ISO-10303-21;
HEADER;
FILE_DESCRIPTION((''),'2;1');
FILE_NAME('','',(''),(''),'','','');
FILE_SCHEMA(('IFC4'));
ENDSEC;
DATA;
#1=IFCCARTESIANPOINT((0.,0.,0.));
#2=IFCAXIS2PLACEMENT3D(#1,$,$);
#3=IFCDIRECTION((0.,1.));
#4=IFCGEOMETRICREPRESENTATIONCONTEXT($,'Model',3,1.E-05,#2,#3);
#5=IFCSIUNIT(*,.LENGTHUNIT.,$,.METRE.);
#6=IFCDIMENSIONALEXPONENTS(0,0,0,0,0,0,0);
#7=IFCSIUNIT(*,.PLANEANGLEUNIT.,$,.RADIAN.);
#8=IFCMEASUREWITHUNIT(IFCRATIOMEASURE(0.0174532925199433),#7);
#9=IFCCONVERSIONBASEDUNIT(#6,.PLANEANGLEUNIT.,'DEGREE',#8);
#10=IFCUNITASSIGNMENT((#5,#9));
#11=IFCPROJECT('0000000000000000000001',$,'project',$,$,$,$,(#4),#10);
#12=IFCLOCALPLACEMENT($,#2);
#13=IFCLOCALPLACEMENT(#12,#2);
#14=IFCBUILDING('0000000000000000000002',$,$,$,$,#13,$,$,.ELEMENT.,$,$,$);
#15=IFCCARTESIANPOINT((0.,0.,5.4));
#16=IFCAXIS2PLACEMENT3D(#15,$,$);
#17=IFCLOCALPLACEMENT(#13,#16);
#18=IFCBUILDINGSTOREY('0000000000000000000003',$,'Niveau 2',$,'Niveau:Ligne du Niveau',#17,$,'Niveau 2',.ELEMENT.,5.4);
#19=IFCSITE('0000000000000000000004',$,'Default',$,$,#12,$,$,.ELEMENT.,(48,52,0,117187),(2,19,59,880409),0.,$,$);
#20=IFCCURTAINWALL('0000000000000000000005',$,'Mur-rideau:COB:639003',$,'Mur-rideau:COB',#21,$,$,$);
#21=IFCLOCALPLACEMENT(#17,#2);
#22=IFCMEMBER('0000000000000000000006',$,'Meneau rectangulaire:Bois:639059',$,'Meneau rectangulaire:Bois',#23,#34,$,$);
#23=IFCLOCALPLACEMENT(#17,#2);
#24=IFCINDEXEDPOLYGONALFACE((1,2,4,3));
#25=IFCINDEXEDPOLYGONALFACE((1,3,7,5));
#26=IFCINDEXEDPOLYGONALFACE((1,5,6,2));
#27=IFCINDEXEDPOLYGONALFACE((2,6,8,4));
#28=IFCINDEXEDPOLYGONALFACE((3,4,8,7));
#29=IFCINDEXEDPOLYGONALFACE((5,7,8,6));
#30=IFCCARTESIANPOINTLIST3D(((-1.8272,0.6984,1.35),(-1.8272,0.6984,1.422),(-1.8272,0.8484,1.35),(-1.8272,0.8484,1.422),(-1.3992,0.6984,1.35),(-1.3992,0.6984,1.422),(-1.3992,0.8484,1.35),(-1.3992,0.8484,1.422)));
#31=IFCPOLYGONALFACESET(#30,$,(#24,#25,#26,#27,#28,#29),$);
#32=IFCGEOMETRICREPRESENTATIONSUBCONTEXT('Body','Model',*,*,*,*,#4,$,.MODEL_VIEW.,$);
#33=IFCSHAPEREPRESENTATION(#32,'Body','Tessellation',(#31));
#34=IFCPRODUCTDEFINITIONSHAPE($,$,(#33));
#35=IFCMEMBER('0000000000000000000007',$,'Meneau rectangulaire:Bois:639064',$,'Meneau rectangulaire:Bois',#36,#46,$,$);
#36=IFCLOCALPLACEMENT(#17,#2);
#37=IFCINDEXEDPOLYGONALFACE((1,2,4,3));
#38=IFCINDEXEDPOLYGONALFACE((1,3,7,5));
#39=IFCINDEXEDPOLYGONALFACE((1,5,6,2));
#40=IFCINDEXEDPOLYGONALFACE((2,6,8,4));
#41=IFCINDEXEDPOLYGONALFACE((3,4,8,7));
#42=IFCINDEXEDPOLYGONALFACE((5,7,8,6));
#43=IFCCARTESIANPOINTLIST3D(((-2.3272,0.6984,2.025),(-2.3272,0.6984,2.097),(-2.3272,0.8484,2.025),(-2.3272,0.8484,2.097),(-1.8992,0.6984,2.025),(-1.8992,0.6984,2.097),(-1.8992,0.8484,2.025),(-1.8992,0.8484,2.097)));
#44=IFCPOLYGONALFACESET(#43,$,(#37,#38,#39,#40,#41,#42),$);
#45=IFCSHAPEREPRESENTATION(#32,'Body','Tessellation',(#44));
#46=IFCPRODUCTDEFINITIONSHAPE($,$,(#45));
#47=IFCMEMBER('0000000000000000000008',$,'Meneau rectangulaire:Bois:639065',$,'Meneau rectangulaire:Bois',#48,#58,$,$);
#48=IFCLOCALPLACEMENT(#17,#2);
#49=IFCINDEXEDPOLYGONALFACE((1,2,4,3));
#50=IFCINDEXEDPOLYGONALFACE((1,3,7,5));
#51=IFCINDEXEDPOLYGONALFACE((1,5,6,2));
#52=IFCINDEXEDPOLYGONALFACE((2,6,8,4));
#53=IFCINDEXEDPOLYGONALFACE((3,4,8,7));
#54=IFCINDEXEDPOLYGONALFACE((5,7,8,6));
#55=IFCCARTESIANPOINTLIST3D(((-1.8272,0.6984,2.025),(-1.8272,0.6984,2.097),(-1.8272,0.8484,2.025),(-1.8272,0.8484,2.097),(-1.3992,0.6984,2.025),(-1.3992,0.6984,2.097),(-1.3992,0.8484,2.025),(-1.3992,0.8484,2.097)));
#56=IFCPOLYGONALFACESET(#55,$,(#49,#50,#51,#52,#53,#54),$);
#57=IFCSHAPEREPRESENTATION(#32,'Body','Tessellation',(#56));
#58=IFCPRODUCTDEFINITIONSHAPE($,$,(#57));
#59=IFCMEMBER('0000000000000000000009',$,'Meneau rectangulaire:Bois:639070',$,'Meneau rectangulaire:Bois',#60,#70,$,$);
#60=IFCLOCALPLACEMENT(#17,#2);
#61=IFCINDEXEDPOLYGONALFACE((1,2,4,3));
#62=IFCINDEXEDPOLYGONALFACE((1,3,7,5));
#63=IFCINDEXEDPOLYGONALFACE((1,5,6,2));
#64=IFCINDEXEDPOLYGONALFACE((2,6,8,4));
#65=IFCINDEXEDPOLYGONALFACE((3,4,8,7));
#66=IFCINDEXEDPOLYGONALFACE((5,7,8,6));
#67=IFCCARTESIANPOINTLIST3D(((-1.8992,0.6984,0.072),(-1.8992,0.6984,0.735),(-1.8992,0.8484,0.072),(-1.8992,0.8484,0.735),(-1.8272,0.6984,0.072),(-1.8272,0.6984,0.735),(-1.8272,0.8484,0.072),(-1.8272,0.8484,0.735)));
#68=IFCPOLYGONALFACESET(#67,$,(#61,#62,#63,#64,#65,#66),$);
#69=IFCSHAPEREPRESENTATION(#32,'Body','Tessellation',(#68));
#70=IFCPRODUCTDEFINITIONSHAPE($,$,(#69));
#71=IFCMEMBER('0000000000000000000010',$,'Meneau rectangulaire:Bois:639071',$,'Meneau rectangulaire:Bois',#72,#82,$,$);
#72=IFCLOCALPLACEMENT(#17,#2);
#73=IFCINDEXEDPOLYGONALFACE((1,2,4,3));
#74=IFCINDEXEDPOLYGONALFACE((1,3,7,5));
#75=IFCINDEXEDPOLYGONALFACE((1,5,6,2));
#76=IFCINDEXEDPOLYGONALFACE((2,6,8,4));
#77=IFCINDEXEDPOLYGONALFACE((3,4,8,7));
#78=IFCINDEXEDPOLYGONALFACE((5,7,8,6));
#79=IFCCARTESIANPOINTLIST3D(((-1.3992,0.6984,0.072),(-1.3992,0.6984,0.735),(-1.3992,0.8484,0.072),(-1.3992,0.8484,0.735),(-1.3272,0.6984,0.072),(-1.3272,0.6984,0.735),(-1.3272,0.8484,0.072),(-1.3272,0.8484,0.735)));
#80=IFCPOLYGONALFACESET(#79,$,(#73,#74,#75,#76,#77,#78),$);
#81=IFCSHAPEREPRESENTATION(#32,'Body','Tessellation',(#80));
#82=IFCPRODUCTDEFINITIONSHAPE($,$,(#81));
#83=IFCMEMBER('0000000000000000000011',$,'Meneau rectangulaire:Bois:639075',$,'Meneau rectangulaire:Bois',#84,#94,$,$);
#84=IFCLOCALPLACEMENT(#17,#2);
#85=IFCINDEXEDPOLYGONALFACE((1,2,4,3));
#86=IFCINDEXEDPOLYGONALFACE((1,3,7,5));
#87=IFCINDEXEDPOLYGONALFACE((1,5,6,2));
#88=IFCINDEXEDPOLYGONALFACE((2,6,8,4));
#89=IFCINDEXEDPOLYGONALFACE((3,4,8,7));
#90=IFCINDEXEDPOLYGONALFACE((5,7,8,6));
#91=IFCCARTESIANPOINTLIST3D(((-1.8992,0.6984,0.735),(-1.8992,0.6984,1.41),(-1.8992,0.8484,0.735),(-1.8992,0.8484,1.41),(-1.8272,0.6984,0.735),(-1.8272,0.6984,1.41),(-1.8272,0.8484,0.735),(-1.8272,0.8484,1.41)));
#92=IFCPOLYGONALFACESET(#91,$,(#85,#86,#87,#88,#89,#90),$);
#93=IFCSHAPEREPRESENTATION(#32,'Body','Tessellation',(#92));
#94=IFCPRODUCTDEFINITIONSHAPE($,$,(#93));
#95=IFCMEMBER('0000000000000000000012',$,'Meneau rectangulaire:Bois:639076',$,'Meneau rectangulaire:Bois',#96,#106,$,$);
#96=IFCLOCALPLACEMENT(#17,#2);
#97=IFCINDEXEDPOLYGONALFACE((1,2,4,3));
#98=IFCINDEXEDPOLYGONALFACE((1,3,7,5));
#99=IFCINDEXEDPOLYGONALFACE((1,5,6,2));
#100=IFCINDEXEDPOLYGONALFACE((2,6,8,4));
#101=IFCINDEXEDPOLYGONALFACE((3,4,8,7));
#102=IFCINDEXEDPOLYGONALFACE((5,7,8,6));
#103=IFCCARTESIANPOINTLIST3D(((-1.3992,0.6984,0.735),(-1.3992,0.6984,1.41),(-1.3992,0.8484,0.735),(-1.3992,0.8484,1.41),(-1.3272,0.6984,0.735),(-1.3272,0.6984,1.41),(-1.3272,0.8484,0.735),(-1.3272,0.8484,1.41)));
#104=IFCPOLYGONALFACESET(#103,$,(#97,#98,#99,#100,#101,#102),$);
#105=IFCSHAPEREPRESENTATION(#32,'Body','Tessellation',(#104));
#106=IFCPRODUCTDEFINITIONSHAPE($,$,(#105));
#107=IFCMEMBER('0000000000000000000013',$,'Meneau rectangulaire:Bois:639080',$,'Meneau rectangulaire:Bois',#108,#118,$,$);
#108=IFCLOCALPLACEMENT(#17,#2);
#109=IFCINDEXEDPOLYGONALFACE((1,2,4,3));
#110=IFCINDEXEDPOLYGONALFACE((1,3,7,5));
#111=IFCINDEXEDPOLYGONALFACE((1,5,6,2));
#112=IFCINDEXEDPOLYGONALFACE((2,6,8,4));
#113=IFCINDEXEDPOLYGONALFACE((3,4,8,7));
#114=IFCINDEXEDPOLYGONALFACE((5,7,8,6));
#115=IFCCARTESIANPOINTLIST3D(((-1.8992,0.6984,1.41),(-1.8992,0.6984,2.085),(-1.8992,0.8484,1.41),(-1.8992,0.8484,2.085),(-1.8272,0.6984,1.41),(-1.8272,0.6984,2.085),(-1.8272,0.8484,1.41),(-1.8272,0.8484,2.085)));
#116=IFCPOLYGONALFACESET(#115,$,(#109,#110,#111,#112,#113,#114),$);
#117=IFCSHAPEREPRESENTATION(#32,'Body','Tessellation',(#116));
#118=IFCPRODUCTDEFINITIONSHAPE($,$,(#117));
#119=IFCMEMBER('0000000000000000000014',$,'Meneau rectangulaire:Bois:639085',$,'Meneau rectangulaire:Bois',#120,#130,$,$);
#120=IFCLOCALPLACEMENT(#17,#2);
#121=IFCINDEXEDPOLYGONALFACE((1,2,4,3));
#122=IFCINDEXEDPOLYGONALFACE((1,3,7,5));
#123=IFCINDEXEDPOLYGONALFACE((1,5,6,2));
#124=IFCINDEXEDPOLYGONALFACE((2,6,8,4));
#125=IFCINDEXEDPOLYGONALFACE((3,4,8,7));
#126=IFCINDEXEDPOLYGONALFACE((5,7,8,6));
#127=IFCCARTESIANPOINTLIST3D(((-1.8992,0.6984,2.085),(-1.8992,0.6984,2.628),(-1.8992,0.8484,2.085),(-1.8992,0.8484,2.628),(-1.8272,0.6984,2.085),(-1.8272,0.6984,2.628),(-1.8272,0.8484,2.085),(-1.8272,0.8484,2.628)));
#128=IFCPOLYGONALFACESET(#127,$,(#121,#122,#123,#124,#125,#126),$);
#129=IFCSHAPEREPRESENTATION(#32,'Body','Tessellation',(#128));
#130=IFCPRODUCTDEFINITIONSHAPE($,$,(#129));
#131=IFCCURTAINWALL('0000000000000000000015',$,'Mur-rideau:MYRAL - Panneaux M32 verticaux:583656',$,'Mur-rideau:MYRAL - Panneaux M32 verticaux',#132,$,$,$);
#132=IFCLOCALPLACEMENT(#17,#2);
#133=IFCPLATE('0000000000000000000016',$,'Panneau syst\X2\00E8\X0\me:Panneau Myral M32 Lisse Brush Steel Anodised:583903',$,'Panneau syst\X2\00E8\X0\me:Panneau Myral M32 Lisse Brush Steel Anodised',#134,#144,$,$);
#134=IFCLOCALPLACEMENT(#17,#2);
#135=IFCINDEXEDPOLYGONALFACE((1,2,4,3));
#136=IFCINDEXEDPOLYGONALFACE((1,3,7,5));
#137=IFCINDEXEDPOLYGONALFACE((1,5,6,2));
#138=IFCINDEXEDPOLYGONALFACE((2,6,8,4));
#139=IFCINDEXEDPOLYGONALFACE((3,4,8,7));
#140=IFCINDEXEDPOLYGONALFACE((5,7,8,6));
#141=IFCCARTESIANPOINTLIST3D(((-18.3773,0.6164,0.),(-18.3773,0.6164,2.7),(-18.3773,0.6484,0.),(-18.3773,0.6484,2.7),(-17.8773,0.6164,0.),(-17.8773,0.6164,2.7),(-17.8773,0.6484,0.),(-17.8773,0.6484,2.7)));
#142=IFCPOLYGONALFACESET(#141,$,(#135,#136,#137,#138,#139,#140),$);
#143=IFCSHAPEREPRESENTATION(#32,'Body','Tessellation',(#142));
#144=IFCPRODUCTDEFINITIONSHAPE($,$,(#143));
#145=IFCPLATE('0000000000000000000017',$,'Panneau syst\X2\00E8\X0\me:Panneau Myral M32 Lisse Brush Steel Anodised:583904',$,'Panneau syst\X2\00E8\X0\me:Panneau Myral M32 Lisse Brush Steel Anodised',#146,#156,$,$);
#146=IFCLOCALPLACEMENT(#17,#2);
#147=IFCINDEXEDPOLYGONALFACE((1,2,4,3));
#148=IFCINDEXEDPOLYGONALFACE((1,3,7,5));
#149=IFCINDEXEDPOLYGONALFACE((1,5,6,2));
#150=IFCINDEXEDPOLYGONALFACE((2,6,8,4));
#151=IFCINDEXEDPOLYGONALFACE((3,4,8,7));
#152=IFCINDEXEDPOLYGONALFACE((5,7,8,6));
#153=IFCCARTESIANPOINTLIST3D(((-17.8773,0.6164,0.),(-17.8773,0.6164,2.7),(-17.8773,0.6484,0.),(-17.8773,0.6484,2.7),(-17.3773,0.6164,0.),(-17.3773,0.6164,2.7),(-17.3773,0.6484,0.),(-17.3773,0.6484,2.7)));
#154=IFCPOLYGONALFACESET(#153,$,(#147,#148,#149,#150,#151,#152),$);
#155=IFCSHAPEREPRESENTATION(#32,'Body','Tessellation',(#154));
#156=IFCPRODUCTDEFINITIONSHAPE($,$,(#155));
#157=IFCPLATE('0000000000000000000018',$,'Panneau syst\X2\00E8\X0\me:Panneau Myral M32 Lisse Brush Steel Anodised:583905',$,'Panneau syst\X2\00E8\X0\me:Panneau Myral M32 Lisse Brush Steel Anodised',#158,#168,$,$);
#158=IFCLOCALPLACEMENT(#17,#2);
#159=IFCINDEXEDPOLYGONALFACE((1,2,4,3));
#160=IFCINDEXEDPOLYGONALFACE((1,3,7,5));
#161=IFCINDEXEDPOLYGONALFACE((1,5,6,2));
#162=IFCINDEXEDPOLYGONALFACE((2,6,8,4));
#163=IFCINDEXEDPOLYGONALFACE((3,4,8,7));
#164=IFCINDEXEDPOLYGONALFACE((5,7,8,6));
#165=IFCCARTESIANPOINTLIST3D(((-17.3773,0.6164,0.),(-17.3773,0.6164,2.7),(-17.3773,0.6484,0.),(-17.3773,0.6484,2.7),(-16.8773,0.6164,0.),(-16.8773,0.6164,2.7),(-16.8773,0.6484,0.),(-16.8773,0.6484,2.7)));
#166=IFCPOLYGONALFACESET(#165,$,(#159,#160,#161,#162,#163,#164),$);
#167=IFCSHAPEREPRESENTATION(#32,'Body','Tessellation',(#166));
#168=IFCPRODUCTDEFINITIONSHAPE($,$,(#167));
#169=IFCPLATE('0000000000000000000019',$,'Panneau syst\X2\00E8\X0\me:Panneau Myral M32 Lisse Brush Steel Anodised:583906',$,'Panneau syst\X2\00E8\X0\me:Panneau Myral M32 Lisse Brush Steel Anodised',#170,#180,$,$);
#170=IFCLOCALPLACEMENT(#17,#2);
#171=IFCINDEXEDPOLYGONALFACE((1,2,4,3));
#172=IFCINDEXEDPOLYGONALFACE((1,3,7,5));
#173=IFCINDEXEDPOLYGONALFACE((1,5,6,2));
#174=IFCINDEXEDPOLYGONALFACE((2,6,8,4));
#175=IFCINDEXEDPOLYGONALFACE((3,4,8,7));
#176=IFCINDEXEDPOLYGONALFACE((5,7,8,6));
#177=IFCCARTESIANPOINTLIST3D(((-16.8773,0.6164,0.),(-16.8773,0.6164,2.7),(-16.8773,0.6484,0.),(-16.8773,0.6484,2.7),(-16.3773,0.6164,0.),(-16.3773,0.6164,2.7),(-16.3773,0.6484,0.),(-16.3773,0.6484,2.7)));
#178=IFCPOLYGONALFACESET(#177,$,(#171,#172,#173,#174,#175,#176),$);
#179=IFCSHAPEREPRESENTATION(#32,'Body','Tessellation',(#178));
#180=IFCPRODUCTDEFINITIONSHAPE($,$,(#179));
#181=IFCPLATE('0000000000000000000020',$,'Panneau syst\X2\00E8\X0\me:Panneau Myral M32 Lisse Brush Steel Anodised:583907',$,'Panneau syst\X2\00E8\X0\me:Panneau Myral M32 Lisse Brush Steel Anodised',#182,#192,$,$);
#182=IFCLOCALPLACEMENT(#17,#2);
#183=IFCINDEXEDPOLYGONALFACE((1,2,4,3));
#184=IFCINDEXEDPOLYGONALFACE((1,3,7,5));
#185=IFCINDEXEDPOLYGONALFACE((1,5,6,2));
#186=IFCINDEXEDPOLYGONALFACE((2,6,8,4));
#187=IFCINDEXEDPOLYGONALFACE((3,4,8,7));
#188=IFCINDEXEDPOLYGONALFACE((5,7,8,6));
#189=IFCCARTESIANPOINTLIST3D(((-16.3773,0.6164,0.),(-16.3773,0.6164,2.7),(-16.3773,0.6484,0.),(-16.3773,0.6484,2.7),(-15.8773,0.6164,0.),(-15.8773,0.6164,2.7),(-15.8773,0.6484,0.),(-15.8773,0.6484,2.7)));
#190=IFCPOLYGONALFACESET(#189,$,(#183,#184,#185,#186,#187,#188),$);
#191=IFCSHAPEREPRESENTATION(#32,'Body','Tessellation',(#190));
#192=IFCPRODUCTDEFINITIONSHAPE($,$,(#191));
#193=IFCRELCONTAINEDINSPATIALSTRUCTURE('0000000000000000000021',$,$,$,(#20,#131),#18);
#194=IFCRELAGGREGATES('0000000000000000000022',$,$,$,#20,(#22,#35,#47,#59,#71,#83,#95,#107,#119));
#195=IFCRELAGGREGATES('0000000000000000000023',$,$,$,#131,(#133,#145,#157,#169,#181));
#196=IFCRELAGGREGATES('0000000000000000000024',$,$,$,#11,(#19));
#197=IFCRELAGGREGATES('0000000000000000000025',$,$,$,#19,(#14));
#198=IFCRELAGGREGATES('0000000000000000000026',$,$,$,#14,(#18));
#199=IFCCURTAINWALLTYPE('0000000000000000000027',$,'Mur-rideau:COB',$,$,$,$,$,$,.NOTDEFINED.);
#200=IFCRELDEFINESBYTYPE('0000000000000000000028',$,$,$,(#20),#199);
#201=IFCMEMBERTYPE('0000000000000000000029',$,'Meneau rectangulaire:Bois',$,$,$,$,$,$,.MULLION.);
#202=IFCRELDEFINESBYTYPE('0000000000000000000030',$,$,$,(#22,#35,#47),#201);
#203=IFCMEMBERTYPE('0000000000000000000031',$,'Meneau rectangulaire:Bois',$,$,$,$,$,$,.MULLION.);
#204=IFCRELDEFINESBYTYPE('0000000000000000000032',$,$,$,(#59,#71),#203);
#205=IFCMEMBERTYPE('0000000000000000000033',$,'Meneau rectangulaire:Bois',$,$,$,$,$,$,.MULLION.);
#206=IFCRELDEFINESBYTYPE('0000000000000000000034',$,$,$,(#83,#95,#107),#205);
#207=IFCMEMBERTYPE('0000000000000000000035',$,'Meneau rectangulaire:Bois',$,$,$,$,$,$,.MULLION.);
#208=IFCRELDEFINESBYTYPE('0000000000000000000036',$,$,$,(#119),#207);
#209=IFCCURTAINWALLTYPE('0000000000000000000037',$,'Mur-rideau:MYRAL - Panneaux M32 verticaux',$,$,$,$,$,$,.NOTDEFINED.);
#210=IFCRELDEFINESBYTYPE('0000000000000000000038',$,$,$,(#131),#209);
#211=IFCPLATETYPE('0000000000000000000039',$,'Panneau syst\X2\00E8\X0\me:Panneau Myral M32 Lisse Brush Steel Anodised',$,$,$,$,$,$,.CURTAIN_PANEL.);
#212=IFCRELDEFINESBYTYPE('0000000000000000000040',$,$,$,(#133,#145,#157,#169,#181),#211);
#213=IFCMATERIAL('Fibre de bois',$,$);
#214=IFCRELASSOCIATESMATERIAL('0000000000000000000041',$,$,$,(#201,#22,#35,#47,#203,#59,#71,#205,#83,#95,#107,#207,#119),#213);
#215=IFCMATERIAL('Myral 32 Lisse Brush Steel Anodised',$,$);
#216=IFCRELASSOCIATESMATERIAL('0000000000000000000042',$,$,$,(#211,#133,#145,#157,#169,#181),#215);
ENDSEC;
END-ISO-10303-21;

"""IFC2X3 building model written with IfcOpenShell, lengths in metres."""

from ifc_helpers import new_model, entity, si_unit, converted_unit, direction, frame, origin, origin_2d_with_axis, place, context, subcontext, project, spatial, rectangle, extrude, source, transform, mapped, material, type_object, type_shapes, element, aggregate, save


model = new_model("IFC2X3")

# Units and contexts
model_context = context("Model", 3, precision=1e-05, world=origin(), true_north=direction((0.0, 1.0)))
body_context = subcontext(model_context, "Body", "Model", "MODEL_VIEW")
ifc_project = project(units=[si_unit("LENGTHUNIT", "METRE"), converted_unit("PLANEANGLEUNIT", "DEGREE", entity("IfcRatioMeasure", 0.0174532925199433), si_unit("PLANEANGLEUNIT", "RADIAN"), dimensions=[0, 0, 0, 0, 0, 0, 0])], contexts=[model_context])

# Site, building, storey
site_placement = place(None, origin())
site = spatial("IfcSite", under=ifc_project, at=site_placement, Name="Default", CompositionType="ELEMENT", RefLatitude=(48, 52, 0, 117187), RefLongitude=(2, 19, 59, 880409), RefElevation=0.0)
building_placement = place(site_placement, origin())
building = spatial("IfcBuilding", under=site, at=building_placement, CompositionType="ELEMENT")
storey_placement = place(building_placement, frame((0.0, 0.0, 5.4)))
storey = spatial("IfcBuildingStorey", under=building, at=storey_placement, Name="Niveau 2", ObjectType="Niveau:Ligne du Niveau", LongName="Niveau 2", CompositionType="ELEMENT", Elevation=5.4)

# Curtain wall, members
curtain_wall_type_1 = type_object("IfcCurtainWallType", Name="Mur-rideau:COB", PredefinedType="NOTDEFINED")
curtain_wall_1_placement = place(storey_placement, frame((0.0, 0.0, -5.4)))
curtain_wall_1 = element("IfcCurtainWall", 1, at=curtain_wall_1_placement, inside=storey, type_object=curtain_wall_type_1, Name="Mur-rideau:COB:639003", ObjectType="Mur-rideau:COB")
ifc_material_1 = material(Name="Fibre de bois")
member_type_1 = type_object("IfcMemberType", Name="Meneau rectangulaire:Bois", PredefinedType="MULLION", material=ifc_material_1)
shared_shape_1 = source(origin(), body_context, "Body", "SweptSolid", [
    extrude(rectangle(XDim=0.15, YDim=0.072, at=origin_2d_with_axis()), frame((-0.024, 0.0, -0.428), z_axis=(0.0, 0.0, 1.0), x_axis=(0.0, -1.0, 0.0)), (0.0, 0.0, 1.0), 0.428),
])
type_shapes(member_type_1, [shared_shape_1])
member_1_placement = place(storey_placement, frame((-1.3992, 0.7734, 1.41), z_axis=(1.0, 0.0, 0.0), x_axis=(0.0, 0.0, 1.0)))
member_1 = element("IfcMember", 2, at=member_1_placement, type_object=member_type_1, material=ifc_material_1, Name="Meneau rectangulaire:Bois:639059", ObjectType="Meneau rectangulaire:Bois", context=body_context, shape_type="MappedRepresentation", body=[
    mapped(shared_shape_1, transform((0.0, 0.0, 0.0), scale=1.0)),
])
member_2_placement = place(storey_placement, frame((-1.8992, 0.7734, 2.085), z_axis=(1.0, 0.0, 0.0), x_axis=(0.0, 0.0, 1.0)))
member_2 = element("IfcMember", 3, at=member_2_placement, type_object=member_type_1, material=ifc_material_1, Name="Meneau rectangulaire:Bois:639064", ObjectType="Meneau rectangulaire:Bois", context=body_context, shape_type="MappedRepresentation", body=[
    mapped(shared_shape_1, transform((0.0, 0.0, 0.0), scale=1.0)),
])
member_3_placement = place(storey_placement, frame((-1.3992, 0.7734, 2.085), z_axis=(1.0, 0.0, 0.0), x_axis=(0.0, 0.0, 1.0)))
member_3 = element("IfcMember", 4, at=member_3_placement, type_object=member_type_1, material=ifc_material_1, Name="Meneau rectangulaire:Bois:639065", ObjectType="Meneau rectangulaire:Bois", context=body_context, shape_type="MappedRepresentation", body=[
    mapped(shared_shape_1, transform((0.0, 0.0, 0.0), scale=1.0)),
])
member_type_2 = type_object("IfcMemberType", Name="Meneau rectangulaire:Bois", PredefinedType="MULLION", material=ifc_material_1)
shared_shape_2 = source(origin(), body_context, "Body", "SweptSolid", [
    extrude(rectangle(XDim=0.15, YDim=0.072, at=origin_2d_with_axis()), frame((-0.024, 0.0, -0.663), z_axis=(0.0, 0.0, 1.0), x_axis=(0.0, -1.0, 0.0)), (0.0, 0.0, 1.0), 0.663),
])
type_shapes(member_type_2, [shared_shape_2])
member_4_placement = place(storey_placement, frame((-1.8392, 0.7734, 0.072), z_axis=(0.0, 0.0, -1.0), x_axis=(1.0, 0.0, 0.0)))
member_4 = element("IfcMember", 5, at=member_4_placement, type_object=member_type_2, material=ifc_material_1, Name="Meneau rectangulaire:Bois:639070", ObjectType="Meneau rectangulaire:Bois", context=body_context, shape_type="MappedRepresentation", body=[
    mapped(shared_shape_2, transform((0.0, 0.0, 0.0), scale=1.0)),
])
member_5_placement = place(storey_placement, frame((-1.3392, 0.7734, 0.072), z_axis=(0.0, 0.0, -1.0), x_axis=(1.0, 0.0, 0.0)))
member_5 = element("IfcMember", 6, at=member_5_placement, type_object=member_type_2, material=ifc_material_1, Name="Meneau rectangulaire:Bois:639071", ObjectType="Meneau rectangulaire:Bois", context=body_context, shape_type="MappedRepresentation", body=[
    mapped(shared_shape_2, transform((0.0, 0.0, 0.0), scale=1.0)),
])
member_type_3 = type_object("IfcMemberType", Name="Meneau rectangulaire:Bois", PredefinedType="MULLION", material=ifc_material_1)
shared_shape_3 = source(origin(), body_context, "Body", "SweptSolid", [
    extrude(rectangle(XDim=0.15, YDim=0.072, at=origin_2d_with_axis()), frame((-0.024, 0.0, -0.675), z_axis=(0.0, 0.0, 1.0), x_axis=(0.0, -1.0, 0.0)), (0.0, 0.0, 1.0), 0.675),
])
type_shapes(member_type_3, [shared_shape_3])
member_6_placement = place(storey_placement, frame((-1.8392, 0.7734, 0.735), z_axis=(0.0, 0.0, -1.0), x_axis=(1.0, 0.0, 0.0)))
member_6 = element("IfcMember", 7, at=member_6_placement, type_object=member_type_3, material=ifc_material_1, Name="Meneau rectangulaire:Bois:639075", ObjectType="Meneau rectangulaire:Bois", context=body_context, shape_type="MappedRepresentation", body=[
    mapped(shared_shape_3, transform((0.0, 0.0, 0.0), scale=1.0)),
])
member_7_placement = place(storey_placement, frame((-1.3392, 0.7734, 0.735), z_axis=(0.0, 0.0, -1.0), x_axis=(1.0, 0.0, 0.0)))
member_7 = element("IfcMember", 8, at=member_7_placement, type_object=member_type_3, material=ifc_material_1, Name="Meneau rectangulaire:Bois:639076", ObjectType="Meneau rectangulaire:Bois", context=body_context, shape_type="MappedRepresentation", body=[
    mapped(shared_shape_3, transform((0.0, 0.0, 0.0), scale=1.0)),
])
member_8_placement = place(storey_placement, frame((-1.8392, 0.7734, 1.41), z_axis=(0.0, 0.0, -1.0), x_axis=(1.0, 0.0, 0.0)))
member_8 = element("IfcMember", 9, at=member_8_placement, type_object=member_type_3, material=ifc_material_1, Name="Meneau rectangulaire:Bois:639080", ObjectType="Meneau rectangulaire:Bois", context=body_context, shape_type="MappedRepresentation", body=[
    mapped(shared_shape_3, transform((0.0, 0.0, 0.0), scale=1.0)),
])
member_type_4 = type_object("IfcMemberType", Name="Meneau rectangulaire:Bois", PredefinedType="MULLION", material=ifc_material_1)
shared_shape_4 = source(origin(), body_context, "Body", "SweptSolid", [
    extrude(rectangle(XDim=0.15, YDim=0.072, at=origin_2d_with_axis()), frame((-0.024, 0.0, -0.543), z_axis=(0.0, 0.0, 1.0), x_axis=(0.0, -1.0, 0.0)), (0.0, 0.0, 1.0), 0.543),
])
type_shapes(member_type_4, [shared_shape_4])
member_9_placement = place(storey_placement, frame((-1.8392, 0.7734, 2.085), z_axis=(0.0, 0.0, -1.0), x_axis=(1.0, 0.0, 0.0)))
member_9 = element("IfcMember", 10, at=member_9_placement, type_object=member_type_4, material=ifc_material_1, Name="Meneau rectangulaire:Bois:639085", ObjectType="Meneau rectangulaire:Bois", context=body_context, shape_type="MappedRepresentation", body=[
    mapped(shared_shape_4, transform((0.0, 0.0, 0.0), scale=1.0)),
])
aggregate(curtain_wall_1, [member_1, member_2, member_3, member_4, member_5, member_6, member_7, member_8, member_9])

# Curtain wall, plates
curtain_wall_type_2 = type_object("IfcCurtainWallType", Name="Mur-rideau:MYRAL - Panneaux M32 verticaux", PredefinedType="NOTDEFINED")
curtain_wall_2_placement = place(storey_placement, frame((0.0, 0.0, -5.4)))
curtain_wall_2 = element("IfcCurtainWall", 11, at=curtain_wall_2_placement, inside=storey, type_object=curtain_wall_type_2, Name="Mur-rideau:MYRAL - Panneaux M32 verticaux:583656", ObjectType="Mur-rideau:MYRAL - Panneaux M32 verticaux")
ifc_material_2 = material(Name="Myral 32 Lisse Brush Steel Anodised")
plate_type = type_object("IfcPlateType", Name="Panneau système:Panneau Myral M32 Lisse Brush Steel Anodised", PredefinedType="CURTAIN_PANEL", material=ifc_material_2)
shared_shape_5 = source(origin(), body_context, "Body", "SweptSolid", [
    extrude(rectangle(XDim=0.032, YDim=0.5, at=origin_2d_with_axis()), frame((0.0, -0.016, 0.0), z_axis=(0.0, 0.0, 1.0), x_axis=(0.0, 1.0, 0.0)), (0.0, 0.0, 1.0), 2.7),
])
type_shapes(plate_type, [shared_shape_5])
plate_1_placement = place(curtain_wall_2_placement, frame((-18.1273, 0.6484, 5.4)))
plate_1 = element("IfcPlate", 12, at=plate_1_placement, type_object=plate_type, material=ifc_material_2, Name="Panneau système:Panneau Myral M32 Lisse Brush Steel Anodised:583903", ObjectType="Panneau système:Panneau Myral M32 Lisse Brush Steel Anodised", context=body_context, shape_type="MappedRepresentation", body=[
    mapped(shared_shape_5, transform((0.0, 0.0, 0.0), scale=1.0)),
])
plate_2_placement = place(curtain_wall_2_placement, frame((-17.6273, 0.6484, 5.4)))
plate_2 = element("IfcPlate", 13, at=plate_2_placement, type_object=plate_type, material=ifc_material_2, Name="Panneau système:Panneau Myral M32 Lisse Brush Steel Anodised:583904", ObjectType="Panneau système:Panneau Myral M32 Lisse Brush Steel Anodised", context=body_context, shape_type="MappedRepresentation", body=[
    mapped(shared_shape_5, transform((0.0, 0.0, 0.0), scale=1.0)),
])
plate_3_placement = place(curtain_wall_2_placement, frame((-17.1273, 0.6484, 5.4)))
plate_3 = element("IfcPlate", 14, at=plate_3_placement, type_object=plate_type, material=ifc_material_2, Name="Panneau système:Panneau Myral M32 Lisse Brush Steel Anodised:583905", ObjectType="Panneau système:Panneau Myral M32 Lisse Brush Steel Anodised", context=body_context, shape_type="MappedRepresentation", body=[
    mapped(shared_shape_5, transform((0.0, 0.0, 0.0), scale=1.0)),
])
plate_4_placement = place(curtain_wall_2_placement, frame((-16.6273, 0.6484, 5.4)))
plate_4 = element("IfcPlate", 15, at=plate_4_placement, type_object=plate_type, material=ifc_material_2, Name="Panneau système:Panneau Myral M32 Lisse Brush Steel Anodised:583906", ObjectType="Panneau système:Panneau Myral M32 Lisse Brush Steel Anodised", context=body_context, shape_type="MappedRepresentation", body=[
    mapped(shared_shape_5, transform((0.0, 0.0, 0.0), scale=1.0)),
])
plate_5_placement = place(curtain_wall_2_placement, frame((-16.1273, 0.6484, 5.4)))
plate_5 = element("IfcPlate", 16, at=plate_5_placement, type_object=plate_type, material=ifc_material_2, Name="Panneau système:Panneau Myral M32 Lisse Brush Steel Anodised:583907", ObjectType="Panneau système:Panneau Myral M32 Lisse Brush Steel Anodised", context=body_context, shape_type="MappedRepresentation", body=[
    mapped(shared_shape_5, transform((0.0, 0.0, 0.0), scale=1.0)),
])
aggregate(curtain_wall_2, [plate_1, plate_2, plate_3, plate_4, plate_5])

save(model, "model.ifc")
